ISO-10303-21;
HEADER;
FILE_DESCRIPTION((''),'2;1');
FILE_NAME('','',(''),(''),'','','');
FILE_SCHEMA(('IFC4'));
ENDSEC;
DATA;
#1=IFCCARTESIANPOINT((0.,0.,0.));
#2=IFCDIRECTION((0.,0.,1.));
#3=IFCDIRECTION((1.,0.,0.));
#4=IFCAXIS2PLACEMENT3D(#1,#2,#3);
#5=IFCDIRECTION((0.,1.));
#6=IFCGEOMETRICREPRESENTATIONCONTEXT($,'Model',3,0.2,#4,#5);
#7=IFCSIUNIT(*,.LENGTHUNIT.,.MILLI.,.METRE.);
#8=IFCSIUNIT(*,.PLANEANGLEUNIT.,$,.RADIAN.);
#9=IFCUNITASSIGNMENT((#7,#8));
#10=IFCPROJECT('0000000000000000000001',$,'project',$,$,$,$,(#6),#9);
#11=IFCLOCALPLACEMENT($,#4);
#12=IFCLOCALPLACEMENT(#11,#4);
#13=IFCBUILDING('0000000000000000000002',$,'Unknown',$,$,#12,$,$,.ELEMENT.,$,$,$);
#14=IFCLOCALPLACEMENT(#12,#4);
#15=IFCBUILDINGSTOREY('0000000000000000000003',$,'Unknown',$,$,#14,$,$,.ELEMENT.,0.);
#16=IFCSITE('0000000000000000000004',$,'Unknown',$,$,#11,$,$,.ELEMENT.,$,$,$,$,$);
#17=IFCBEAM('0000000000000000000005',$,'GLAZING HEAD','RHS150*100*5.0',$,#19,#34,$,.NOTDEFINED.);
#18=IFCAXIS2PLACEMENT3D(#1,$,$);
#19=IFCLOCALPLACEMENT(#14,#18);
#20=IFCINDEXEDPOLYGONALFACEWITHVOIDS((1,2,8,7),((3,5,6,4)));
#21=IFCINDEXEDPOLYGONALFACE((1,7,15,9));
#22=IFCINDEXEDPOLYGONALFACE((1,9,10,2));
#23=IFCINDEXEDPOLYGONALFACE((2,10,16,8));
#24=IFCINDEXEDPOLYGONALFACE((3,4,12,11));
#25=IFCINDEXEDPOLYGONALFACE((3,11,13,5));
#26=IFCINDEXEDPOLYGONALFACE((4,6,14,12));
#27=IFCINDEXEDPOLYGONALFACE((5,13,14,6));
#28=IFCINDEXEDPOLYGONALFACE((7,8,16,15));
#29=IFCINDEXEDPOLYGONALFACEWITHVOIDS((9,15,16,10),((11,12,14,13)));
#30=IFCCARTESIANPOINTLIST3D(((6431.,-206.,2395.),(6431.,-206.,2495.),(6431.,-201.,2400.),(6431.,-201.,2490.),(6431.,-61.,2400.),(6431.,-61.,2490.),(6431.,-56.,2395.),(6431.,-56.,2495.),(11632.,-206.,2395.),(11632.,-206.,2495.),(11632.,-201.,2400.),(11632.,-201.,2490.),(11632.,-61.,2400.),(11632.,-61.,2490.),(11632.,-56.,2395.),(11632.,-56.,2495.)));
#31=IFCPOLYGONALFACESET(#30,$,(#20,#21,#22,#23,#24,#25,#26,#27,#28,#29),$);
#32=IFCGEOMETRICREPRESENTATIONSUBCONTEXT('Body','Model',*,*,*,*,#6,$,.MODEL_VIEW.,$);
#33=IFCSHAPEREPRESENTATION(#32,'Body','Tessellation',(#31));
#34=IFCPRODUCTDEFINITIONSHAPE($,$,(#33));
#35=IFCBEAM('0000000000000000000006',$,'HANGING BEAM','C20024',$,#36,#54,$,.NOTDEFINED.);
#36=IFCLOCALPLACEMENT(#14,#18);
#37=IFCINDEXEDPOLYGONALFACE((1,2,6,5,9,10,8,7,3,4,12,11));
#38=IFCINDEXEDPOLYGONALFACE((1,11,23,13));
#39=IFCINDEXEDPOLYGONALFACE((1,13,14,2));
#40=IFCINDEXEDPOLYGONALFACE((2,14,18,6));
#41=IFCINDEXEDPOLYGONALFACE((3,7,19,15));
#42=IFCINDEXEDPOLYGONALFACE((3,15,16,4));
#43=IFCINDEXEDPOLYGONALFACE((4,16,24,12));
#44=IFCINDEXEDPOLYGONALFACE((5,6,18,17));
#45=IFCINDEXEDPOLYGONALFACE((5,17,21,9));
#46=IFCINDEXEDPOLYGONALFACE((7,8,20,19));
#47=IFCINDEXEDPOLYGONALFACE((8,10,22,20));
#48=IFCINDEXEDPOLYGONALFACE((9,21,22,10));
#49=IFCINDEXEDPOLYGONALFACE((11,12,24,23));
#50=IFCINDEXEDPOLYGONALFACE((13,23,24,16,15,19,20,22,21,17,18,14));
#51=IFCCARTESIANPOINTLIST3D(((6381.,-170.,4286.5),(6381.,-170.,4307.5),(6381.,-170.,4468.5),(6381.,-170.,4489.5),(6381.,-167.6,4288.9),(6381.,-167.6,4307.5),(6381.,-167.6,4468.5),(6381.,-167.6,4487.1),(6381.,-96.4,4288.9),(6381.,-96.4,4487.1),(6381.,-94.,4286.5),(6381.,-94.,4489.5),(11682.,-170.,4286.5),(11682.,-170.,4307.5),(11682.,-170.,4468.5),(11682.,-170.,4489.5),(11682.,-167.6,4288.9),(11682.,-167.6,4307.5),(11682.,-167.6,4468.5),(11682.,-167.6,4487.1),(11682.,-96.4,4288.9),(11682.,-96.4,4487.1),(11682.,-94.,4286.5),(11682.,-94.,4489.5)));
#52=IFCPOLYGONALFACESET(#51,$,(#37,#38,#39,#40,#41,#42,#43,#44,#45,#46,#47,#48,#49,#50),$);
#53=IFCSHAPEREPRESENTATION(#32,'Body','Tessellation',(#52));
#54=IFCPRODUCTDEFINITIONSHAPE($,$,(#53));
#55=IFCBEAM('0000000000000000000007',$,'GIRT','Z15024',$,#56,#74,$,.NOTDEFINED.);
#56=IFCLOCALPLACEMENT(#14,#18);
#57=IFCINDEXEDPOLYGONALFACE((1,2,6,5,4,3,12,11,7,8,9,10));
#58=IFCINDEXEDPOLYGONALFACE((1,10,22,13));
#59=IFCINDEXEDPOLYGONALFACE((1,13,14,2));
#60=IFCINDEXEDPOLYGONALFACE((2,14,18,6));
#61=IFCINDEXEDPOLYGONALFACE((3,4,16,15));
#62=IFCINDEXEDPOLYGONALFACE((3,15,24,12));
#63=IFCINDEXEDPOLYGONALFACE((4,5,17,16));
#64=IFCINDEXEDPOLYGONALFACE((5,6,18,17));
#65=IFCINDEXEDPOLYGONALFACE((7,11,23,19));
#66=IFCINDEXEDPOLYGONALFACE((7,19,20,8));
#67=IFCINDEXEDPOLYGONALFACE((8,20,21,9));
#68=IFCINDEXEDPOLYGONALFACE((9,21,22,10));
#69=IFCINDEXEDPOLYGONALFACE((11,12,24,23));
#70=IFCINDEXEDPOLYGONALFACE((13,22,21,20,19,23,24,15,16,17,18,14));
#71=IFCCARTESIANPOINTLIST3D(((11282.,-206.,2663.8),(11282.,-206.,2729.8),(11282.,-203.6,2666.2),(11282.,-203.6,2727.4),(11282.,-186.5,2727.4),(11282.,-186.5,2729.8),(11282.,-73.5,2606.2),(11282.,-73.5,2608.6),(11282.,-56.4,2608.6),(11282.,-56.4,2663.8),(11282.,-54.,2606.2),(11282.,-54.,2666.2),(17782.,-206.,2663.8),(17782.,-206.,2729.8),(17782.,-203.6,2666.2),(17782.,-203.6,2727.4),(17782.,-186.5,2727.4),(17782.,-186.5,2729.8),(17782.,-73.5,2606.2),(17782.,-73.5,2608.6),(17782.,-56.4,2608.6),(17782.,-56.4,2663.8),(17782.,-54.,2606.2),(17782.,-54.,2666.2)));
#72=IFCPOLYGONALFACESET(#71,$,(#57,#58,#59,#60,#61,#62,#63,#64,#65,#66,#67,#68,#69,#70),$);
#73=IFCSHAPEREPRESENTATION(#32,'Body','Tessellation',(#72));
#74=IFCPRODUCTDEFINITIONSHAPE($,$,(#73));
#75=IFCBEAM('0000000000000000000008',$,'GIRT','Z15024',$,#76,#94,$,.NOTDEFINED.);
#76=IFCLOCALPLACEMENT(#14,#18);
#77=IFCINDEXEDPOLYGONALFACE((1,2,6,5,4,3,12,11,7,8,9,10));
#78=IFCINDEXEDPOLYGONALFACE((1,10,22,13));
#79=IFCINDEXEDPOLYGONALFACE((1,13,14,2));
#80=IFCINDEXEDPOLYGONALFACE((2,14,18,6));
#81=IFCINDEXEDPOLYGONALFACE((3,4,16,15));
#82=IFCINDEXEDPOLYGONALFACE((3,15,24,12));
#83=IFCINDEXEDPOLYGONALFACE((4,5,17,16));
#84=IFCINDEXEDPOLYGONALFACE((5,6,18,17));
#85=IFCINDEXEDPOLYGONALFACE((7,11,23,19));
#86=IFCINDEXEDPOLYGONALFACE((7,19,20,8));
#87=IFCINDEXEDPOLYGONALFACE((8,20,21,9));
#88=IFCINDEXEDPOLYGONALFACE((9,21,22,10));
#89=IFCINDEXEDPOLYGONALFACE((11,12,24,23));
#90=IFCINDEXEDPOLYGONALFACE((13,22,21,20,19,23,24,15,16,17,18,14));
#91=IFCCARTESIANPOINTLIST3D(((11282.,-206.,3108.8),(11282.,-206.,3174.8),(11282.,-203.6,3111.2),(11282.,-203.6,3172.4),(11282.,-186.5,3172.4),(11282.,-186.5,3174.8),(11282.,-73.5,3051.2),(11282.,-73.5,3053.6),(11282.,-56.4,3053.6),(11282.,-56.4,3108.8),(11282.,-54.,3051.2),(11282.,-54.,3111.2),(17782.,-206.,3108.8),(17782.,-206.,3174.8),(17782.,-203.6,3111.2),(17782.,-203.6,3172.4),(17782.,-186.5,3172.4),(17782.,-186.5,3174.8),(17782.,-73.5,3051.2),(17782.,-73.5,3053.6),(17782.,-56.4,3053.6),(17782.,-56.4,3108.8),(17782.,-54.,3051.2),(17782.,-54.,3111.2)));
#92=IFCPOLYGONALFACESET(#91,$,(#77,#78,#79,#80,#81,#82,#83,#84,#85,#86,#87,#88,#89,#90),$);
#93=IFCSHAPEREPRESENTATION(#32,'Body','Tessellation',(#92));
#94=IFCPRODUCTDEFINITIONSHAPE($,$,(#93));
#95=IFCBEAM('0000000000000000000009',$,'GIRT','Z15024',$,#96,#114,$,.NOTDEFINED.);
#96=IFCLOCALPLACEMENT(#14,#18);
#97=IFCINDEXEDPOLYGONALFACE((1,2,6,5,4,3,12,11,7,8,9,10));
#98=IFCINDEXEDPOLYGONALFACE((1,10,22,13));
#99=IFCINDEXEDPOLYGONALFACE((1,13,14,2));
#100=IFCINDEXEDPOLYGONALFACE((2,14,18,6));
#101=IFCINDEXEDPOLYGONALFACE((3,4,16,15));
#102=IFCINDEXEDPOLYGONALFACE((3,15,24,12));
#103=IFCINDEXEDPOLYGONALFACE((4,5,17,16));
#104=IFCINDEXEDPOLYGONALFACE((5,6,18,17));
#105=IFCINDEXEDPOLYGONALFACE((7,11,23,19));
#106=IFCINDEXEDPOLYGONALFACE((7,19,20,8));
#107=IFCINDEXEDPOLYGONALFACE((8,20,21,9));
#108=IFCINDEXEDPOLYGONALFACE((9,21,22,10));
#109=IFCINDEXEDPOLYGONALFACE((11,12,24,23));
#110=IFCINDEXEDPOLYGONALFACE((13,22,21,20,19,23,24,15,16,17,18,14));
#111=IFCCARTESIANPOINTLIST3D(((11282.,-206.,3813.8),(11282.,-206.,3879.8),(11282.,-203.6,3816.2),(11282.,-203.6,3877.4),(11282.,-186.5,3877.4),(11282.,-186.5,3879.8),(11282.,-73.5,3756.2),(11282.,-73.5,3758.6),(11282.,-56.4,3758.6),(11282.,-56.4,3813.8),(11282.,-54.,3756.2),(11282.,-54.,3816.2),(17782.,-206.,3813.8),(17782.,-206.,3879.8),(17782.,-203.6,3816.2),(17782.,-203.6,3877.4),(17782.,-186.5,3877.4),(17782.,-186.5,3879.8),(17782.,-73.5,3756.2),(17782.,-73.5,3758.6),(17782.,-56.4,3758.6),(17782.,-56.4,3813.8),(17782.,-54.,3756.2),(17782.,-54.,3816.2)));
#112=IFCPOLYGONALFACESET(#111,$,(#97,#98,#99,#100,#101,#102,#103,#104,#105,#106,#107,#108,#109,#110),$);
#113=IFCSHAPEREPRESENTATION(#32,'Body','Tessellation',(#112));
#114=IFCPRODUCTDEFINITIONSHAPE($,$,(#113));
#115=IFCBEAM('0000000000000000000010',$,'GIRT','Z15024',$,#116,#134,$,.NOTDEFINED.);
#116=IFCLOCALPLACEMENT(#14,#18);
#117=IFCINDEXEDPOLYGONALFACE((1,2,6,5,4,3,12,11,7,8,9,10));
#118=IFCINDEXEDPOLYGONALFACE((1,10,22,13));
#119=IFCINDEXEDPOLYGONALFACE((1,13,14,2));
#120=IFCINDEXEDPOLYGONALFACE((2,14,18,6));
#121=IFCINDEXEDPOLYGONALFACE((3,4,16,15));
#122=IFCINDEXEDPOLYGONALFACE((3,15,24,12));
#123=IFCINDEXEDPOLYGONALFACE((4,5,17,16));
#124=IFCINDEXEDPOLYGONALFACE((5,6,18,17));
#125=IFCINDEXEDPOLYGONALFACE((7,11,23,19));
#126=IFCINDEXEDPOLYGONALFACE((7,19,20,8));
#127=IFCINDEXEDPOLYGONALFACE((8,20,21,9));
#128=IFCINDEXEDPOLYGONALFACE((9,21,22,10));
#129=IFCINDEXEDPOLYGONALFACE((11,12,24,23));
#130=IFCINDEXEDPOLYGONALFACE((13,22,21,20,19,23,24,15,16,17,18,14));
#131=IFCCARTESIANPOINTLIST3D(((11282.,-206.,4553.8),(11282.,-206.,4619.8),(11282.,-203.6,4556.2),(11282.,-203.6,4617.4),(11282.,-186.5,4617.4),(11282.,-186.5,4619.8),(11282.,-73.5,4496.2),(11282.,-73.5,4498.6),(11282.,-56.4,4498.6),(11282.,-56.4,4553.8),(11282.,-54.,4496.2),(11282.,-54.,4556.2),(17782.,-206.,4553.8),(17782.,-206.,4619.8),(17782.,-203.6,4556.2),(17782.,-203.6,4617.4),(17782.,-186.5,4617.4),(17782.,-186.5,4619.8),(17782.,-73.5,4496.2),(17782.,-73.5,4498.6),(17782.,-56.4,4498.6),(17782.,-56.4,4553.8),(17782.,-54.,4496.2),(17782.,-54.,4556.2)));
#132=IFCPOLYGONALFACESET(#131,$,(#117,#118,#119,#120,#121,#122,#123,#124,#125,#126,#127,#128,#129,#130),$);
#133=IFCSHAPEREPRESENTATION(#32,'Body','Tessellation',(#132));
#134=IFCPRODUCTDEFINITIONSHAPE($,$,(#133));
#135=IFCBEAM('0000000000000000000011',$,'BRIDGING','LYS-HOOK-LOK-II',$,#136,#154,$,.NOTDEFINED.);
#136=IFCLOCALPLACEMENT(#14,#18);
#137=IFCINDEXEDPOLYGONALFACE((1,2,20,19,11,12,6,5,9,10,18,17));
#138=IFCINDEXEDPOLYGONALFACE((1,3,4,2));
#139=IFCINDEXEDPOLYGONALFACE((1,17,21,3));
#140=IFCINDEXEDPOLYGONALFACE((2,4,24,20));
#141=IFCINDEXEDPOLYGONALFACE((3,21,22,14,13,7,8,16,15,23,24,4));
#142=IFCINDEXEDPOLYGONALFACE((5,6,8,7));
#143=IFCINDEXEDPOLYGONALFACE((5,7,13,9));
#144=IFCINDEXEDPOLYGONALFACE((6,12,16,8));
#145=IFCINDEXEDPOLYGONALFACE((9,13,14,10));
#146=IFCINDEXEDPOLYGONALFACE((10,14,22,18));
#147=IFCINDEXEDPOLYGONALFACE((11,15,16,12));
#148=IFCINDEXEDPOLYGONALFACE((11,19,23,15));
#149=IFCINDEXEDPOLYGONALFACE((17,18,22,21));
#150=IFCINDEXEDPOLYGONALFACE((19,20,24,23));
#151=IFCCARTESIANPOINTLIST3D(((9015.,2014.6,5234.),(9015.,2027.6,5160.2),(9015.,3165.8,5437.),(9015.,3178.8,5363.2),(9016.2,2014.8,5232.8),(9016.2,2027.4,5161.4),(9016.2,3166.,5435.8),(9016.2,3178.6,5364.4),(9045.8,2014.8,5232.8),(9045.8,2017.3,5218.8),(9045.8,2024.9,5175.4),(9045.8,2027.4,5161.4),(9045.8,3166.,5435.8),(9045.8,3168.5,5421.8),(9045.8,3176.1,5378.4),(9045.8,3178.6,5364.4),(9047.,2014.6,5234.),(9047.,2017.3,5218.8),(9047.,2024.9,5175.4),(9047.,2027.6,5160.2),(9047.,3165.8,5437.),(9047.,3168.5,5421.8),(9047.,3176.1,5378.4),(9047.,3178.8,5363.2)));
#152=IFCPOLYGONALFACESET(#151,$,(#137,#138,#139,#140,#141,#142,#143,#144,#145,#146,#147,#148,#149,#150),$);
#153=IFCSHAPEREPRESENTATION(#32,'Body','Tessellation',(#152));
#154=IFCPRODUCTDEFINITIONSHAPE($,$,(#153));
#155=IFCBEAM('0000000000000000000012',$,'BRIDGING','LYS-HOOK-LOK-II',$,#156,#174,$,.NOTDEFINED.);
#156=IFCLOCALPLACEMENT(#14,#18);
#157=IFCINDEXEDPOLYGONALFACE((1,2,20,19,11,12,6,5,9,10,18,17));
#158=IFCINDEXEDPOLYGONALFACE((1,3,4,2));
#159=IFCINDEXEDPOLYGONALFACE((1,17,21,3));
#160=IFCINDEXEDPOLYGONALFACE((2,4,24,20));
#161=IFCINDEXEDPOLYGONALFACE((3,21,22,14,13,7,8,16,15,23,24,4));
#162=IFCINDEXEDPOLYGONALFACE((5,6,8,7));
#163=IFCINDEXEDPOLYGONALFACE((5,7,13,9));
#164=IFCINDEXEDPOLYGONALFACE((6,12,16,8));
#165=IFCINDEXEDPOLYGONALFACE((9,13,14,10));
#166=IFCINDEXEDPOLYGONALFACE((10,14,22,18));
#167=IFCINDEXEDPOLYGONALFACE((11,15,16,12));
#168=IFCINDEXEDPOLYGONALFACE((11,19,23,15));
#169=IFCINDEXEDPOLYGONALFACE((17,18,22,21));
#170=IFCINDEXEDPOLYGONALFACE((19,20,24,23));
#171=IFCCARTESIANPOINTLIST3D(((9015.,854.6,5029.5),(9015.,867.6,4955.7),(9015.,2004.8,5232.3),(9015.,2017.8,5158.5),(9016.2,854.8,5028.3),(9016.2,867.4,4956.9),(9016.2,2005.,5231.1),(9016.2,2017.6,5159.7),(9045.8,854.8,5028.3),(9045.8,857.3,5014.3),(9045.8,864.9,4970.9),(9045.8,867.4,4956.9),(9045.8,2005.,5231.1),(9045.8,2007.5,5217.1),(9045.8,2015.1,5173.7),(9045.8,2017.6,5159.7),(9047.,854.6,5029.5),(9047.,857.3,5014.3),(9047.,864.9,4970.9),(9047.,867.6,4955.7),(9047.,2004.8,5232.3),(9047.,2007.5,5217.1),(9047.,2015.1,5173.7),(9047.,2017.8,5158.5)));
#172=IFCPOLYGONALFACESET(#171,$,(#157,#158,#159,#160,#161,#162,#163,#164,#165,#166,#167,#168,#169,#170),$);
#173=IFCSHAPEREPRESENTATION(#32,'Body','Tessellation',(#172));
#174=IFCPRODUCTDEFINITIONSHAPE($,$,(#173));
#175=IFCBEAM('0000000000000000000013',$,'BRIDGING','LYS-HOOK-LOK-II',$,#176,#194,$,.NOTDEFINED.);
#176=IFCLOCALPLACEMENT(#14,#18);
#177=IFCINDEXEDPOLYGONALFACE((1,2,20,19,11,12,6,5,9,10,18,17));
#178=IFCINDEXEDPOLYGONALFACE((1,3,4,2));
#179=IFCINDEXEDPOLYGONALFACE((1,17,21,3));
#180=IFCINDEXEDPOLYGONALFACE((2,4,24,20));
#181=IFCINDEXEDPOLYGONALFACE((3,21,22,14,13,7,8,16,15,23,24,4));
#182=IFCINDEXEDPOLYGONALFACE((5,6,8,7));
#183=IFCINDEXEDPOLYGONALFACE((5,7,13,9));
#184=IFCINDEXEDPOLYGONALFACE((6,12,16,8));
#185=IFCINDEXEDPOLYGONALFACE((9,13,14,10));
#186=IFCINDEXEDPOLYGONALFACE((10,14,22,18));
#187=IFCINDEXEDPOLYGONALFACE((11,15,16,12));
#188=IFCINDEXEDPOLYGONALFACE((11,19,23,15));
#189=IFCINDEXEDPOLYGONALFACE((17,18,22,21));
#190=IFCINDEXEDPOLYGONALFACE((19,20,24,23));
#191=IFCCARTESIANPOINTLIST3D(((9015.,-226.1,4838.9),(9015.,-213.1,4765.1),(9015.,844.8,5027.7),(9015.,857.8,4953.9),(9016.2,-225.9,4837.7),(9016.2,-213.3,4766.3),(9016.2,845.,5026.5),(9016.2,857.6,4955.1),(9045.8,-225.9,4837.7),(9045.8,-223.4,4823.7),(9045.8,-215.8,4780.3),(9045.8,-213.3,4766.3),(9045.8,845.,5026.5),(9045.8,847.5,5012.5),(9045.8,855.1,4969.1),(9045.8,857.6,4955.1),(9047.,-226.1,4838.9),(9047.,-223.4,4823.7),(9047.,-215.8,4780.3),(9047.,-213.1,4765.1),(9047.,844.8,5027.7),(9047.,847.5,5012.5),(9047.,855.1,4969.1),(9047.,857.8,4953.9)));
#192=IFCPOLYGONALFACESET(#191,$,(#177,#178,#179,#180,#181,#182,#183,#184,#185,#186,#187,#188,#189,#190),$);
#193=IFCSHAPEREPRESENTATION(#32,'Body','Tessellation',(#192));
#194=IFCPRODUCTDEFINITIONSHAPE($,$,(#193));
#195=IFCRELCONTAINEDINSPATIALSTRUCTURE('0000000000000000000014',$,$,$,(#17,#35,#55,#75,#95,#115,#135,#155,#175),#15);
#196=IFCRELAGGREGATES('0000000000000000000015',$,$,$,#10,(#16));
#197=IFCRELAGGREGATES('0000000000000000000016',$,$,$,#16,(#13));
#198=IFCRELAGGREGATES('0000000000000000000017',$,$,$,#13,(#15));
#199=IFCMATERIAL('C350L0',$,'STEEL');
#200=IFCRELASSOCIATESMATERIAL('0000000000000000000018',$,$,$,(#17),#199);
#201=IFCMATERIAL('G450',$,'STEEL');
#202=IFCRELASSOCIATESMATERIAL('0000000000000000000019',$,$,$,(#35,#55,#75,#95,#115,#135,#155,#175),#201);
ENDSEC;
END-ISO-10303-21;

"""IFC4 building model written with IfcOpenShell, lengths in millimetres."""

from ifc_helpers import new_model, si_unit, direction, frame, origin_with_axes, place, context, subcontext, project, spatial, line, indexed_curve, outline, extrude, material, element, save


model = new_model("IFC4")

# Units and contexts
model_context = context("Model", 3, precision=0.2, world=origin_with_axes(), true_north=direction((0.0, 1.0)))
body_context = subcontext(model_context, "Body", "Model", "MODEL_VIEW")
ifc_project = project(units=[si_unit("LENGTHUNIT", "METRE", prefix="MILLI"), si_unit("PLANEANGLEUNIT", "RADIAN")], contexts=[model_context])

# Site, building, storey
site_placement = place(None, origin_with_axes())
site = spatial("IfcSite", under=ifc_project, at=site_placement, Name="Unknown", CompositionType="ELEMENT")
building_placement = place(site_placement, origin_with_axes())
building = spatial("IfcBuilding", under=site, at=building_placement, Name="Unknown", CompositionType="ELEMENT")
storey_placement = place(building_placement, origin_with_axes())
storey = spatial("IfcBuildingStorey", under=building, at=storey_placement, Name="Unknown", CompositionType="ELEMENT", Elevation=0.0)

# Shared definitions
ifc_material_1 = material(Name="G450", Category="STEEL")

# Beams
ifc_material_2 = material(Name="C350L0", Category="STEEL")
beam_1_placement = place(storey_placement, frame((6431.0, -131.0, 2445.0), z_axis=(0.0, 0.0, 1.0), x_axis=(1.0, 0.0, 0.0)))
element("IfcBeam", 1, at=beam_1_placement, inside=storey, material=ifc_material_2, Name="GLAZING HEAD", Description="RHS150*100*5.0", PredefinedType="NOTDEFINED", context=body_context, shape_type="SolidModel", body=[
    extrude(outline(indexed_curve([(-50.0, -75.0), (50.0, -75.0), (50.0, 75.0), (-50.0, 75.0)], segments=[line(1, 2, 3, 4, 1)]), holes=[indexed_curve([(-45.0, -70.0), (-45.0, 70.0), (45.0, 70.0), (45.0, -70.0)], segments=[line(1, 2, 3, 4, 1)])]), frame((0.0, 0.0, 0.0), z_axis=(-1.0, 0.0, 0.0), x_axis=(0.0, 0.0, 1.0)), (0.0, 0.0, -1.0), 5201.0),
])
beam_2_placement = place(storey_placement, frame((6381.0, -132.0, 4388.0), z_axis=(0.0, -1.0, 0.0), x_axis=(1.0, 0.0, 0.0)))
element("IfcBeam", 2, at=beam_2_placement, inside=storey, material=ifc_material_1, Name="HANGING BEAM", Description="C20024", PredefinedType="NOTDEFINED", context=body_context, shape_type="SolidModel", body=[
    extrude(outline(indexed_curve([(38.0, -101.5), (38.0, -80.5), (35.6, -80.5), (35.6, -99.1), (-35.6, -99.1), (-35.6, 99.1), (35.6, 99.1), (35.6, 80.5), (38.0, 80.5), (38.0, 101.5), (-38.0, 101.5), (-38.0, -101.5)], segments=[line(1, 2, 3, 4, 5, 6, 7, 8, 9, 10, 11, 12, 1)])), frame((0.0, 0.0, 0.0), z_axis=(-1.0, 0.0, 0.0), x_axis=(0.0, 0.0, 1.0)), (0.0, 0.0, -1.0), 5301.0),
])
for number, where, z_axis, x_axis, name in (
    (3, (11282.0, -130.0, 2665.0), (0.0, 0.0, -1.0), (1.0, 0.0, 0.0), "GIRT"),
    (4, (11282.0, -130.0, 3110.0), (0.0, 0.0, -1.0), (1.0, 0.0, 0.0), "GIRT"),
    (5, (11282.0, -130.0, 3815.0), (0.0, 0.0, -1.0), (1.0, 0.0, 0.0), "GIRT"),
    (6, (11282.0, -130.0, 4555.0), (0.0, 0.0, -1.0), (1.0, 0.0, 0.0), "GIRT"),
):
    element("IfcBeam", number, at=place(storey_placement, frame(where, z_axis=z_axis, x_axis=x_axis)), inside=storey, material=ifc_material_1, Name=name, Description="Z15024", PredefinedType="NOTDEFINED", context=body_context, shape_type="SolidModel", body=[
        extrude(outline(indexed_curve([(58.8, -76.0), (58.8, -56.5), (56.4, -56.5), (56.4, -73.6), (1.2, -73.6), (1.2, 76.0), (-64.8, 76.0), (-64.8, 56.5), (-62.4, 56.5), (-62.4, 73.6), (-1.2, 73.6), (-1.2, -76.0)], segments=[line(1, 2, 3, 4, 5, 6, 7, 8, 9, 10, 11, 12, 1)])), frame((0.0, 0.0, 0.0), z_axis=(-1.0, 0.0, 0.0), x_axis=(0.0, 0.0, 1.0)), (0.0, 0.0, -1.0), 6500.0),
    ])
beam_3_placement = place(storey_placement, frame((9031.0, 2021.1, 5197.1), z_axis=(1.0, 0.0, 0.0), x_axis=(0.0, 0.984806, 0.173658)))
element("IfcBeam", 7, at=beam_3_placement, inside=storey, material=ifc_material_1, Name="BRIDGING", Description="LYS-HOOK-LOK-II", PredefinedType="NOTDEFINED", context=body_context, shape_type="SolidModel", body=[
    extrude(outline(indexed_curve([(16.0, -37.5), (16.0, -22.0), (14.8, -22.0), (14.8, -36.3), (-14.8, -36.3), (-14.8, 36.3), (14.8, 36.3), (14.8, 22.0), (16.0, 22.0), (16.0, 37.5), (-16.0, 37.5), (-16.0, -37.5)], segments=[line(1, 2, 3, 4, 5, 6, 7, 8, 9, 10, 11, 12, 1)])), frame((0.0, 0.0, 0.0), z_axis=(-1.0, 0.0, 0.0), x_axis=(0.0, 0.0, 1.0)), (0.0, 0.0, -1.0), 1169.0),
])
beam_4_placement = place(storey_placement, frame((9031.0, 861.1, 4992.6), z_axis=(1.0, 0.0, 0.0), x_axis=(0.0, 0.984809, 0.173639)))
element("IfcBeam", 8, at=beam_4_placement, inside=storey, material=ifc_material_1, Name="BRIDGING", Description="LYS-HOOK-LOK-II", PredefinedType="NOTDEFINED", context=body_context, shape_type="SolidModel", body=[
    extrude(outline(indexed_curve([(16.0, -37.5), (16.0, -22.0), (14.8, -22.0), (14.8, -36.3), (-14.8, -36.3), (-14.8, 36.3), (14.8, 36.3), (14.8, 22.0), (16.0, 22.0), (16.0, 37.5), (-16.0, 37.5), (-16.0, -37.5)], segments=[line(1, 2, 3, 4, 5, 6, 7, 8, 9, 10, 11, 12, 1)])), frame((0.0, 0.0, 0.0), z_axis=(-1.0, 0.0, 0.0), x_axis=(0.0, 0.0, 1.0)), (0.0, 0.0, -1.0), 1167.9),
])
beam_5_placement = place(storey_placement, frame((9031.0, -219.6, 4802.0), z_axis=(1.0, 0.0, 0.0), x_axis=(0.0, 0.984812, 0.173623)))
element("IfcBeam", 9, at=beam_5_placement, inside=storey, material=ifc_material_1, Name="BRIDGING", Description="LYS-HOOK-LOK-II", PredefinedType="NOTDEFINED", context=body_context, shape_type="SolidModel", body=[
    extrude(outline(indexed_curve([(16.0, -37.5), (16.0, -22.0), (14.8, -22.0), (14.8, -36.3), (-14.8, -36.3), (-14.8, 36.3), (14.8, 36.3), (14.8, 22.0), (16.0, 22.0), (16.0, 37.5), (-16.0, 37.5), (-16.0, -37.5)], segments=[line(1, 2, 3, 4, 5, 6, 7, 8, 9, 10, 11, 12, 1)])), frame((0.0, 0.0, 0.0), z_axis=(-1.0, 0.0, 0.0), x_axis=(0.0, 0.0, 1.0)), (0.0, 0.0, -1.0), 1087.4),
])

save(model, "model.ifc")
